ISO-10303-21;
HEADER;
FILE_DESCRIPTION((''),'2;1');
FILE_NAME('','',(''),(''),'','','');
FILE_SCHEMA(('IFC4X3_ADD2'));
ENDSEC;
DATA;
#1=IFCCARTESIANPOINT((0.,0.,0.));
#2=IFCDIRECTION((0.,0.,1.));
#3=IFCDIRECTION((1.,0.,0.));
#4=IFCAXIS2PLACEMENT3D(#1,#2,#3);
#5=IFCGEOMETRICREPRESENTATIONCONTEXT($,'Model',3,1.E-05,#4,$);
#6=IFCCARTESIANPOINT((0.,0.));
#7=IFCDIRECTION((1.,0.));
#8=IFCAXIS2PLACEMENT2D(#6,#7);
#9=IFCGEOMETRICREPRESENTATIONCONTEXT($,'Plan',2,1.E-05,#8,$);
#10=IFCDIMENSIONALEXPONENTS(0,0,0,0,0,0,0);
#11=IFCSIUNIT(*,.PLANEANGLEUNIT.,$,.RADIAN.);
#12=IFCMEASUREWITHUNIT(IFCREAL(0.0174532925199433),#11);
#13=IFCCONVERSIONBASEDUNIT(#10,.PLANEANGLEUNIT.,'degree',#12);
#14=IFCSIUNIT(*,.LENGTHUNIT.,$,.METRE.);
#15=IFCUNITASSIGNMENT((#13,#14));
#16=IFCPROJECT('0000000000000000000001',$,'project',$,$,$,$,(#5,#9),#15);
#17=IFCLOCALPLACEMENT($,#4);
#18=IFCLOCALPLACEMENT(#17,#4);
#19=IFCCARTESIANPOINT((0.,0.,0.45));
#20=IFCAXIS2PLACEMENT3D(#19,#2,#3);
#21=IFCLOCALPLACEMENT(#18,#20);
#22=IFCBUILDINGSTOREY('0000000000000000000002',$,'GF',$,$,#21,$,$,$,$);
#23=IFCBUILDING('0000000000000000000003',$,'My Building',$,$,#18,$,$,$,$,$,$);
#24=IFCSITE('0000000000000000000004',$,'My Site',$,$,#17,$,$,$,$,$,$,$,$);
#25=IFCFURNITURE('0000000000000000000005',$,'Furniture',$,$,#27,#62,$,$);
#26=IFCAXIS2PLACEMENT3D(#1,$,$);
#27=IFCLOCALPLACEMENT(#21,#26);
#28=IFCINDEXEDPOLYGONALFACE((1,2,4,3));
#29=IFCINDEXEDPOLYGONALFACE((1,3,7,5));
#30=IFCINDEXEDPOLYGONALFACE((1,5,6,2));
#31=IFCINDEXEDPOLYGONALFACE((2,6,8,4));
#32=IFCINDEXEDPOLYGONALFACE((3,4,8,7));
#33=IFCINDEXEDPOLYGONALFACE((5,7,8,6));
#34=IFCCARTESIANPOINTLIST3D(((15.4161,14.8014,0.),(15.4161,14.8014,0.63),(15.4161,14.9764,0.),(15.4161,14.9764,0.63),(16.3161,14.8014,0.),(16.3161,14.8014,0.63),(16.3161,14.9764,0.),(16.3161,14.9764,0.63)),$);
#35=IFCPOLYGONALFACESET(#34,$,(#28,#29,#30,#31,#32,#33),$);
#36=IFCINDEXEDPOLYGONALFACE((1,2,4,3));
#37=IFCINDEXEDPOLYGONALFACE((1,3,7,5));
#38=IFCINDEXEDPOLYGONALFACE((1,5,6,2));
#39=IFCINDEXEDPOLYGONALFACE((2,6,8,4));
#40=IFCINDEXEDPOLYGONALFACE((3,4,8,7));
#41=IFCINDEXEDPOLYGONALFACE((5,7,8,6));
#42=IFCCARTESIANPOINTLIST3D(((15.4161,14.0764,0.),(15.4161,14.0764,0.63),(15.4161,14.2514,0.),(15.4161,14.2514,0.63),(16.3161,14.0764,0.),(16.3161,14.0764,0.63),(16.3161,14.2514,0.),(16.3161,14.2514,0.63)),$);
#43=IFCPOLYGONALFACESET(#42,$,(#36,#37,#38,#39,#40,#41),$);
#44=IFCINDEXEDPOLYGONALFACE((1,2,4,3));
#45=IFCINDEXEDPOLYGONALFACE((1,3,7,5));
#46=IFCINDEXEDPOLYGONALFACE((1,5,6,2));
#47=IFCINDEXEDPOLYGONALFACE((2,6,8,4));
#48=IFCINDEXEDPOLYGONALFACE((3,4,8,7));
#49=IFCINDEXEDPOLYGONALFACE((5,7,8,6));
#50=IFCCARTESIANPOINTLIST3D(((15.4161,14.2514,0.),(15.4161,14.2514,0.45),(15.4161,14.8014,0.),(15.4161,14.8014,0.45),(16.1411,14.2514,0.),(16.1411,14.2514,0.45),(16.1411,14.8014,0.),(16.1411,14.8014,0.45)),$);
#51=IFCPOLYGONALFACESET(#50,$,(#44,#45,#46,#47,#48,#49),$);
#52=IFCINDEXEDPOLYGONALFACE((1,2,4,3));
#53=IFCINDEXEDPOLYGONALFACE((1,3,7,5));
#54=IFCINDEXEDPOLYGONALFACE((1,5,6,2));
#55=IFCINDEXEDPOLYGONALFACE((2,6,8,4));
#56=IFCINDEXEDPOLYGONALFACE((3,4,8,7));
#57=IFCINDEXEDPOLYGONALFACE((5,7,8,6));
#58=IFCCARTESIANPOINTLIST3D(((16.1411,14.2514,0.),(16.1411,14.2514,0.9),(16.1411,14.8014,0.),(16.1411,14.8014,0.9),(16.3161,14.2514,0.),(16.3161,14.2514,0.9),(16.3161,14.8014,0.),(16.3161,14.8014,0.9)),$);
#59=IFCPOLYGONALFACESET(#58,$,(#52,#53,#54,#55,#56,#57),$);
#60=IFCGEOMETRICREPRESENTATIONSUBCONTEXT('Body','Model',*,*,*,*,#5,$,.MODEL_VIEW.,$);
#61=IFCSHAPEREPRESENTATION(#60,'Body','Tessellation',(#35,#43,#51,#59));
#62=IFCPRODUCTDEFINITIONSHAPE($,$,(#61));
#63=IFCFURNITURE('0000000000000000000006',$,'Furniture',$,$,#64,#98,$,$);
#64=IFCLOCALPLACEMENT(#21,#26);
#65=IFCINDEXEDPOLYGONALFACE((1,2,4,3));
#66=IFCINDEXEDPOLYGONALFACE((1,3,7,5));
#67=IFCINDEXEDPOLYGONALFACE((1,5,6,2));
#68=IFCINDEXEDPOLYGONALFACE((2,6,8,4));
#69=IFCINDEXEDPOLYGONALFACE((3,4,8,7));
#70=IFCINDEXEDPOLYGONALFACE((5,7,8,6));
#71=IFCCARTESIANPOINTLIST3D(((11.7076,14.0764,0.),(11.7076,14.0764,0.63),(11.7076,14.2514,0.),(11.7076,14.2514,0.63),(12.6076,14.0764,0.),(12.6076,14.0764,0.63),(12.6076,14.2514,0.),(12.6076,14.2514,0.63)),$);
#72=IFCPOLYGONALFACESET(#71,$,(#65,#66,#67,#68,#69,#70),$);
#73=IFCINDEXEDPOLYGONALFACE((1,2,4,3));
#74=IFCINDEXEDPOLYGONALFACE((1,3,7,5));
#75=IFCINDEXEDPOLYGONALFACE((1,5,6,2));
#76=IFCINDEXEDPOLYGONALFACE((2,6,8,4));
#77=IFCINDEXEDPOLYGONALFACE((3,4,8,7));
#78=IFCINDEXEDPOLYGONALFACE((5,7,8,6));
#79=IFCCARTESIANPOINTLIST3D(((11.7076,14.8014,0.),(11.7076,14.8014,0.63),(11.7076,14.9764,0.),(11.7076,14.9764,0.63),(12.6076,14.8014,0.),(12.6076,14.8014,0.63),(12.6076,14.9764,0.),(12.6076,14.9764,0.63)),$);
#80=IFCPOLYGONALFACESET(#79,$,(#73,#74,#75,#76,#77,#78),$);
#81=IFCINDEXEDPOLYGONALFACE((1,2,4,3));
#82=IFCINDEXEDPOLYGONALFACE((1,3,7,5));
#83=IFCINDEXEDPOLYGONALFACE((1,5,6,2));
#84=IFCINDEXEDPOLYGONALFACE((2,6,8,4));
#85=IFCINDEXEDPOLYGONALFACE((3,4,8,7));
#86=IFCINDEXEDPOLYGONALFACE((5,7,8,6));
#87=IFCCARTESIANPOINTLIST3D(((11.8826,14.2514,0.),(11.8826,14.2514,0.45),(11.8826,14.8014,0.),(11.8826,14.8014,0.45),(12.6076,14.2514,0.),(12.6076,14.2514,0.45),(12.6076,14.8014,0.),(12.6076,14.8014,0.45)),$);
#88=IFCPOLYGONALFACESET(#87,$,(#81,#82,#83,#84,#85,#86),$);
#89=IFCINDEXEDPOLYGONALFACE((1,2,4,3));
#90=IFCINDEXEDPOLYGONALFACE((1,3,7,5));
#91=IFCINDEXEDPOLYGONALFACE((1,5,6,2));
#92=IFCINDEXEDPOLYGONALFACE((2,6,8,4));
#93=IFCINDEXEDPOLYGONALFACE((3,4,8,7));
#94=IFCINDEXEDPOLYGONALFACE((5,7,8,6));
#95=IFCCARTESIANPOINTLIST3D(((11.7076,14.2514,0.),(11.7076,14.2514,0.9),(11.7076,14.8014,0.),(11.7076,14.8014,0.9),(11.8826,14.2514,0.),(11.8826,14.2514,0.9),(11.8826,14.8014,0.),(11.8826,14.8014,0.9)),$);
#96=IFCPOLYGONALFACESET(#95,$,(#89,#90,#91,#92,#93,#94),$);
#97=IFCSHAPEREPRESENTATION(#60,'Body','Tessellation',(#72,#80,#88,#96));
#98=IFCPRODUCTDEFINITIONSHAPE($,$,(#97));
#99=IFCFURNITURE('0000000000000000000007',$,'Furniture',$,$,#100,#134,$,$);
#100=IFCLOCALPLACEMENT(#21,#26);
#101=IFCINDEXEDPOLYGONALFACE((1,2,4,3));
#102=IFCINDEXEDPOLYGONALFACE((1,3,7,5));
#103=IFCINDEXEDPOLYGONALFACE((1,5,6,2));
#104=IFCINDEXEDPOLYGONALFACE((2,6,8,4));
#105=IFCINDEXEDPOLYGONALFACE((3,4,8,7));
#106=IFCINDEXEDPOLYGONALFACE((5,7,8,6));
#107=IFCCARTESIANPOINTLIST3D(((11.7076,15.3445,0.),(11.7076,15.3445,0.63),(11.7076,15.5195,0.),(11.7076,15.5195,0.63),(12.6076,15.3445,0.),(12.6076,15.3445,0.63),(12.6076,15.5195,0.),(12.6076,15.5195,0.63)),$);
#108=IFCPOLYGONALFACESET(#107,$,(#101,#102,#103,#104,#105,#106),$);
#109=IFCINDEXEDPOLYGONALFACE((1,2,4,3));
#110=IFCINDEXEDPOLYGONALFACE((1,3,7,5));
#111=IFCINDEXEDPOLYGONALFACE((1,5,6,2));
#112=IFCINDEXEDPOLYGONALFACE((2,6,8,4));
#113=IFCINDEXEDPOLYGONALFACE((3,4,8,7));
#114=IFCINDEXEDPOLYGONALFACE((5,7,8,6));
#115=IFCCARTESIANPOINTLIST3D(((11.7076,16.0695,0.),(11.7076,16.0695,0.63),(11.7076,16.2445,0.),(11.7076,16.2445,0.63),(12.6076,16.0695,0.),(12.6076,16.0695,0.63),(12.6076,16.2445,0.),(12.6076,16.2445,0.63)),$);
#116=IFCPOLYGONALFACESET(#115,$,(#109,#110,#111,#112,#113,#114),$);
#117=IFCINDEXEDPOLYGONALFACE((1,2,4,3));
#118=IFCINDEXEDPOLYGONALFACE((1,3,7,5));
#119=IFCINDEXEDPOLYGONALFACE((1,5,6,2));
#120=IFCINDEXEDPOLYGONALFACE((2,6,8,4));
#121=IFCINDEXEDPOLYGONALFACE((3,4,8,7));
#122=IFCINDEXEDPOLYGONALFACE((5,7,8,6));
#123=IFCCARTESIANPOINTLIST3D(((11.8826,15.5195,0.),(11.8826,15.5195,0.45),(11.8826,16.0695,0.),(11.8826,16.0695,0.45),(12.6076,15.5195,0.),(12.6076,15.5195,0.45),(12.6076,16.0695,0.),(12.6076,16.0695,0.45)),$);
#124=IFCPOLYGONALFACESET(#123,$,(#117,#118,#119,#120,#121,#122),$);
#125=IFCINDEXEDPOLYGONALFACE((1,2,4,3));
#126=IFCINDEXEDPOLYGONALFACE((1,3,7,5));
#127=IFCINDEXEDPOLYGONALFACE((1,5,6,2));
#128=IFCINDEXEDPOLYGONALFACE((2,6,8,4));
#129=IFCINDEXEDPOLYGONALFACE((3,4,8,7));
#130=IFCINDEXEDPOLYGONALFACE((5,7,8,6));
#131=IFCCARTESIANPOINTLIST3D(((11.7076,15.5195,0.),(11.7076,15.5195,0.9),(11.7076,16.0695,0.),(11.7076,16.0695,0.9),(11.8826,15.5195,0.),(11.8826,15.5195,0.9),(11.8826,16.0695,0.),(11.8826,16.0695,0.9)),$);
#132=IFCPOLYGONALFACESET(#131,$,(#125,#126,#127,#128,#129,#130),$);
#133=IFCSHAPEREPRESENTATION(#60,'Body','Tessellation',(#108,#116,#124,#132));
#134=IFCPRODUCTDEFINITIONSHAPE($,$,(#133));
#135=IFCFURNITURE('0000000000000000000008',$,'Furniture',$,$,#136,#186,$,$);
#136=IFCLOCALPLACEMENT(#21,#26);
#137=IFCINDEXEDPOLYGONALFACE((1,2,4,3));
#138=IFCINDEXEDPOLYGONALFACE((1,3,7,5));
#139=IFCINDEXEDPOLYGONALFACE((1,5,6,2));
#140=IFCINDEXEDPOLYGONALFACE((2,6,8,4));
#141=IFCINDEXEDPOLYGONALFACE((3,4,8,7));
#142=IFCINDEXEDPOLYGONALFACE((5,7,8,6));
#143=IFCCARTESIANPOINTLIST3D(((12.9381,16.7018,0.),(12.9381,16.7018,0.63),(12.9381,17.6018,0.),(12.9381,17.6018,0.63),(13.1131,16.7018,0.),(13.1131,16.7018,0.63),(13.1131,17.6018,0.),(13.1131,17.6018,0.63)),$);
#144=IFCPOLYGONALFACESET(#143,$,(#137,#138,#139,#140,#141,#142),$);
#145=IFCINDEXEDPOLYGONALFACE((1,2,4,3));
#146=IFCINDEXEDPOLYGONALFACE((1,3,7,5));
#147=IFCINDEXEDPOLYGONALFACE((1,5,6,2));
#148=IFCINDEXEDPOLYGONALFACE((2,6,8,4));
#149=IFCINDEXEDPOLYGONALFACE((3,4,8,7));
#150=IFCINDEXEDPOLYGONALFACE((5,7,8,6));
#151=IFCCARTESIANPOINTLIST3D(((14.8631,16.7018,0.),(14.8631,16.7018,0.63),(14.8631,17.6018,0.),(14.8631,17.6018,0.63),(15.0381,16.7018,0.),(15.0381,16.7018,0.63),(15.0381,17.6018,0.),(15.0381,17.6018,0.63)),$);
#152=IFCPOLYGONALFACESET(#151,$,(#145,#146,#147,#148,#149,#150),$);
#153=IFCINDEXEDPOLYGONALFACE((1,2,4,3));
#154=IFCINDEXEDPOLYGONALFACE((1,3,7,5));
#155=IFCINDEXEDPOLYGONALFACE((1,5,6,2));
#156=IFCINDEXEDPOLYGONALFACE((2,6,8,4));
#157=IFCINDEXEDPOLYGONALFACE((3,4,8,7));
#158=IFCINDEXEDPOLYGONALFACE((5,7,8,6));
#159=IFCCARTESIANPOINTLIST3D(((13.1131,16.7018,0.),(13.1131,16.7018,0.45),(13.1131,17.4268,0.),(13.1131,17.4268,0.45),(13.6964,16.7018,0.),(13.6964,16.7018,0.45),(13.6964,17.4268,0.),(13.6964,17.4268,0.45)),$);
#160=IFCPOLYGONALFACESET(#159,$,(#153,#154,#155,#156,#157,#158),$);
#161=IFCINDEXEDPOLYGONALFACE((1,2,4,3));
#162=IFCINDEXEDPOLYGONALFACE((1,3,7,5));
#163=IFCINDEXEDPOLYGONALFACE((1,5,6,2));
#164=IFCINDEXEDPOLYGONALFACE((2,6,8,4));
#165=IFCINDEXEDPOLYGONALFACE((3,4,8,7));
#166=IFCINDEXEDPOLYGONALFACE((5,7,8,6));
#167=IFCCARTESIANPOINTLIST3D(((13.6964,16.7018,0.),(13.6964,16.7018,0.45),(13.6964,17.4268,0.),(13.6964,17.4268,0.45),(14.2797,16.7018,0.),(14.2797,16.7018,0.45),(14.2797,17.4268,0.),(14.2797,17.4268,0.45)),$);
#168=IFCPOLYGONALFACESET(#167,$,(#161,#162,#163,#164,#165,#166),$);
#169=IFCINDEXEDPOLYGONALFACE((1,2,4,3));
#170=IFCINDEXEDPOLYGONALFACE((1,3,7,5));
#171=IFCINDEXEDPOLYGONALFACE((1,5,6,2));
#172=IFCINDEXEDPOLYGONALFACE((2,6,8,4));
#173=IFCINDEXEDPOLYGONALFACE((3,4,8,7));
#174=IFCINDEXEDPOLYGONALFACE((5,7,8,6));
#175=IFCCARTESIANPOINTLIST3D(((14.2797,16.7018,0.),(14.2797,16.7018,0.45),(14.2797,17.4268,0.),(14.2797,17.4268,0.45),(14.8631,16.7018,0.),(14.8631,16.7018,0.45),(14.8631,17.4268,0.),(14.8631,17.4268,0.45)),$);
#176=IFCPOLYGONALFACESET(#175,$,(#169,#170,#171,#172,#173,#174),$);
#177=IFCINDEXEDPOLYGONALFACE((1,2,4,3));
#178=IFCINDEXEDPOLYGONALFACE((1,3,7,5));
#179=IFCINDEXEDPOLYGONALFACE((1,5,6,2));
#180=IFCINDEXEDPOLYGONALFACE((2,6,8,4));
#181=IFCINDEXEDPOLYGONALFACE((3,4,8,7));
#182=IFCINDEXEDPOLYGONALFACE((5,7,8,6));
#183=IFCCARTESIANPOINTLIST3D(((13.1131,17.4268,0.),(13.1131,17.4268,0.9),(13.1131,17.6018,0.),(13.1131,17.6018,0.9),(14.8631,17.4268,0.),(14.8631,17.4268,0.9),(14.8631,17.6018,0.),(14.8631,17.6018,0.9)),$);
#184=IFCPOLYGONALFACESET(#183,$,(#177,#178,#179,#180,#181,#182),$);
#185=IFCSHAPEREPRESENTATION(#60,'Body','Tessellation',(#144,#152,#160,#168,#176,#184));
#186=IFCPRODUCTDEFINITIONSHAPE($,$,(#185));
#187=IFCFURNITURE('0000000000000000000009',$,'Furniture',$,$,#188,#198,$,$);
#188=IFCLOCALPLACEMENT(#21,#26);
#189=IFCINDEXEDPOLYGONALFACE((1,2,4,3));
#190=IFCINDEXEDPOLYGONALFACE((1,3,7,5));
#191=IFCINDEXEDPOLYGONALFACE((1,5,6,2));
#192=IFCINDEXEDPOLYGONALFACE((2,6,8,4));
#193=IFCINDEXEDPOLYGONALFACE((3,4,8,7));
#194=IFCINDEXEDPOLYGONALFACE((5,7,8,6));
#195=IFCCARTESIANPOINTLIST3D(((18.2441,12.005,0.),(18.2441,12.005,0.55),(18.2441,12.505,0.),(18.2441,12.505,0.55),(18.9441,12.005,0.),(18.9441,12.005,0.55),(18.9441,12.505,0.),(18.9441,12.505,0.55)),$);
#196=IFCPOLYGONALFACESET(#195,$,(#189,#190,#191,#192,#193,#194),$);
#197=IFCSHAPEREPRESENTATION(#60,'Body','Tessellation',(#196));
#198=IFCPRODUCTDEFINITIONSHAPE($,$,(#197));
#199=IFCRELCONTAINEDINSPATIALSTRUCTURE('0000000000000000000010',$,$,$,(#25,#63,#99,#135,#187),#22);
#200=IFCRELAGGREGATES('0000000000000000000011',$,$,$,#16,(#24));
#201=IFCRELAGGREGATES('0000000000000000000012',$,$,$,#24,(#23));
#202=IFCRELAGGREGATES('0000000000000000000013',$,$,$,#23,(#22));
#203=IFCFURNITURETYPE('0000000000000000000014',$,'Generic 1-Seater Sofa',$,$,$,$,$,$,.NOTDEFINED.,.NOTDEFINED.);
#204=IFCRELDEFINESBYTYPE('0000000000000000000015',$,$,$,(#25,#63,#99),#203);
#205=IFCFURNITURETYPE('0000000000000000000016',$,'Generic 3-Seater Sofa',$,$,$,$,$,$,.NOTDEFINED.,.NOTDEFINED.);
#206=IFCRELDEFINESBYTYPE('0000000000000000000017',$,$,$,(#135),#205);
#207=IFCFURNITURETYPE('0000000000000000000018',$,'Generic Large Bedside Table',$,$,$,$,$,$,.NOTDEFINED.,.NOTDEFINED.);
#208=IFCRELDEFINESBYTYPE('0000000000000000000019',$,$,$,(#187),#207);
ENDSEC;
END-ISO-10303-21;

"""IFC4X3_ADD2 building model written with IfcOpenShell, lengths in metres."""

from ifc_helpers import new_model, entity, si_unit, converted_unit, frame, origin_with_axes, origin_2d_with_axis, place, context, subcontext, project, spatial, line, indexed_curve, outline, extrude, shape, source, transform, mapped, type_object, type_shapes, element, save


model = new_model("IFC4X3_ADD2")

# Units and contexts
model_context = context("Model", 3, precision=1e-05, world=origin_with_axes())
plan_context = context("Plan", 2, precision=1e-05, world=origin_2d_with_axis())
body_context_1 = subcontext(model_context, "Body", "Model", "MODEL_VIEW")
body_context_2 = subcontext(plan_context, "Body", "Plan", "PLAN_VIEW")
ifc_project = project(units=[converted_unit("PLANEANGLEUNIT", "degree", entity("IfcReal", 0.0174532925199433), si_unit("PLANEANGLEUNIT", "RADIAN"), dimensions=[0, 0, 0, 0, 0, 0, 0]), si_unit("LENGTHUNIT", "METRE")], contexts=[model_context, plan_context])

# Site, building, storey
site_placement = place(None, origin_with_axes())
site = spatial("IfcSite", under=ifc_project, at=site_placement, Name="My Site")
building_placement = place(site_placement, origin_with_axes())
building = spatial("IfcBuilding", under=site, at=building_placement, Name="My Building")
storey_placement = place(building_placement, frame((0.0, 0.0, 0.45), z_axis=(0.0, 0.0, 1.0), x_axis=(1.0, 0.0, 0.0)))
storey = spatial("IfcBuildingStorey", under=building, at=storey_placement, Name="GF")

# Furniture
furniture_type_1 = type_object("IfcFurnitureType", Name="Generic 1-Seater Sofa", AssemblyPlace="NOTDEFINED", PredefinedType="NOTDEFINED")
shared_shape_1 = source(origin_with_axes(), body_context_1, "Body", "SweptSolid", [
    extrude(outline(indexed_curve([(0.0, 0.0), (0.175, 0.0), (0.175, 0.9), (0.0, 0.9)], segments=[line(1, 2, 3, 4, 1)])), frame((-0.45, -0.9, 0.0), z_axis=(0.0, 0.0, 1.0), x_axis=(1.0, 0.0, 0.0)), (0.0, 0.0, 1.0), 0.63),
    extrude(outline(indexed_curve([(0.0, 0.0), (0.175, 0.0), (0.175, 0.9), (0.0, 0.9)], segments=[line(1, 2, 3, 4, 1)])), frame((0.275, -0.9, 0.0), z_axis=(0.0, 0.0, 1.0), x_axis=(1.0, 0.0, 0.0)), (0.0, 0.0, 1.0), 0.63),
    extrude(outline(indexed_curve([(0.175, 0.0), (0.725, 0.0), (0.725, 0.725), (0.175, 0.725)], segments=[line(1, 2, 3, 4, 1)])), frame((-0.45, -0.9, 0.0), z_axis=(0.0, 0.0, 1.0), x_axis=(1.0, 0.0, 0.0)), (0.0, 0.0, 1.0), 0.45),
    extrude(outline(indexed_curve([(0.175, 0.725), (0.725, 0.725), (0.725, 0.9), (0.175, 0.9)], segments=[line(1, 2, 3, 4, 1)])), frame((-0.45, -0.9, 0.0), z_axis=(0.0, 0.0, 1.0), x_axis=(1.0, 0.0, 0.0)), (0.0, 0.0, 1.0), 0.9),
])
shared_shape_2 = source(origin_with_axes(), body_context_2, "Body", "Annotation2D", [
    entity("IfcGeometricCurveSet", [entity("IfcIndexedPolyCurve", entity("IfcCartesianPointList2D", [[0.275, -0.175], [0.275, -0.9], [0.45, -0.9], [0.45, 0.0], [0.275, 0.0], [0.275, -0.9], [-0.275, -0.9], [-0.275, 0.0], [-0.275, -0.175], [0.275, -0.175], [0.275, 0.0], [-0.275, 0.0], [-0.45, 0.0], [-0.45, -0.9], [-0.275, -0.9], [-0.275, -0.175]]))]),
])
type_shapes(furniture_type_1, [shared_shape_1, shared_shape_2])
for number, where, z_axis, x_axis, name in (
    (1, (16.3161, 14.5264, 0.0), (0.0, 0.0, 1.0), (0.0, -1.0, 0.0), "Furniture"),
    (2, (11.7076, 14.5264, 0.0), (0.0, 0.0, 1.0), (0.000003, 1.0, 0.0), "Furniture"),
    (3, (11.7076, 15.7945, 0.0), (0.0, 0.0, 1.0), (0.000003, 1.0, 0.0), "Furniture"),
):
    element("IfcFurniture", number, at=place(storey_placement, frame(where, z_axis=z_axis, x_axis=x_axis)), inside=storey, type_object=furniture_type_1, Name=name, shapes=[
        shape(body_context_1, "Body", "MappedRepresentation", [mapped(shared_shape_1, transform((0.0, 0.0, 0.0), x_axis=(1.0, 0.0, 0.0), y_axis=(0.0, 1.0, 0.0), z_axis=(0.0, 0.0, 1.0), scale=1.0))]),
        shape(body_context_2, "Body", "MappedRepresentation", [mapped(shared_shape_2, transform((0.0, 0.0, 0.0), x_axis=(1.0, 0.0, 0.0), y_axis=(0.0, 1.0, 0.0), z_axis=(0.0, 0.0, 1.0), scale=1.0))]),
    ])
furniture_type_2 = type_object("IfcFurnitureType", Name="Generic 3-Seater Sofa", AssemblyPlace="NOTDEFINED", PredefinedType="NOTDEFINED")
shared_shape_3 = source(origin_with_axes(), body_context_1, "Body", "SweptSolid", [
    extrude(outline(indexed_curve([(0.0, 0.0), (0.175, 0.0), (0.175, 0.9), (0.0, 0.9)], segments=[line(1, 2, 3, 4, 1)])), frame((-1.05, -0.9, 0.0), z_axis=(0.0, 0.0, 1.0), x_axis=(1.0, 0.0, 0.0)), (0.0, 0.0, 1.0), 0.63),
    extrude(outline(indexed_curve([(0.0, 0.0), (0.175, 0.0), (0.175, 0.9), (0.0, 0.9)], segments=[line(1, 2, 3, 4, 1)])), frame((0.875, -0.9, 0.0), z_axis=(0.0, 0.0, 1.0), x_axis=(1.0, 0.0, 0.0)), (0.0, 0.0, 1.0), 0.63),
    extrude(outline(indexed_curve([(0.175, 0.0), (0.7583, 0.0), (0.7583, 0.725), (0.175, 0.725)], segments=[line(1, 2, 3, 4, 1)])), frame((-1.05, -0.9, 0.0), z_axis=(0.0, 0.0, 1.0), x_axis=(1.0, 0.0, 0.0)), (0.0, 0.0, 1.0), 0.45),
    extrude(outline(indexed_curve([(0.7583, 0.0), (1.3417, 0.0), (1.3417, 0.725), (0.7583, 0.725)], segments=[line(1, 2, 3, 4, 1)])), frame((-1.05, -0.9, 0.0), z_axis=(0.0, 0.0, 1.0), x_axis=(1.0, 0.0, 0.0)), (0.0, 0.0, 1.0), 0.45),
    extrude(outline(indexed_curve([(1.3417, 0.0), (1.925, 0.0), (1.925, 0.725), (1.3417, 0.725)], segments=[line(1, 2, 3, 4, 1)])), frame((-1.05, -0.9, 0.0), z_axis=(0.0, 0.0, 1.0), x_axis=(1.0, 0.0, 0.0)), (0.0, 0.0, 1.0), 0.45),
    extrude(outline(indexed_curve([(0.175, 0.725), (1.925, 0.725), (1.925, 0.9), (0.175, 0.9)], segments=[line(1, 2, 3, 4, 1)])), frame((-1.05, -0.9, 0.0), z_axis=(0.0, 0.0, 1.0), x_axis=(1.0, 0.0, 0.0)), (0.0, 0.0, 1.0), 0.9),
])
shared_shape_4 = source(origin_with_axes(), body_context_2, "Body", "Curve2D", [
    entity("IfcIndexedPolyCurve", entity("IfcCartesianPointList2D", [[-1.05, -0.9], [-0.875, -0.9], [-0.875, 0.0], [-1.05, 0.0]]), [entity("IfcLineIndex", [1, 2, 3, 4, 1])]),
    entity("IfcIndexedPolyCurve", entity("IfcCartesianPointList2D", [[0.875, -0.9], [1.05, -0.9], [1.05, 0.0], [0.875, 0.0]]), [entity("IfcLineIndex", [1, 2, 3, 4, 1])]),
    entity("IfcIndexedPolyCurve", entity("IfcCartesianPointList2D", [[-0.875, -0.9], [-0.2917, -0.9], [-0.2917, -0.175], [-0.875, -0.175]]), [entity("IfcLineIndex", [1, 2, 3, 4, 1])]),
    entity("IfcIndexedPolyCurve", entity("IfcCartesianPointList2D", [[-0.2917, -0.9], [0.2917, -0.9], [0.2917, -0.175], [-0.2917, -0.175]]), [entity("IfcLineIndex", [1, 2, 3, 4, 1])]),
    entity("IfcIndexedPolyCurve", entity("IfcCartesianPointList2D", [[0.2917, -0.9], [0.875, -0.9], [0.875, -0.175], [0.2917, -0.175]]), [entity("IfcLineIndex", [1, 2, 3, 4, 1])]),
    entity("IfcIndexedPolyCurve", entity("IfcCartesianPointList2D", [[-0.875, -0.175], [0.875, -0.175], [0.875, 0.0], [-0.875, 0.0]]), [entity("IfcLineIndex", [1, 2, 3, 4, 1])]),
])
type_shapes(furniture_type_2, [shared_shape_3, shared_shape_4])
furniture_1_placement = place(storey_placement, frame((13.9881, 17.6018, 0.0), z_axis=(0.0, 0.0, 1.0), x_axis=(1.0, 0.0, 0.0)))
element("IfcFurniture", 4, at=furniture_1_placement, inside=storey, type_object=furniture_type_2, Name="Furniture", shapes=[
    shape(body_context_1, "Body", "MappedRepresentation", [mapped(shared_shape_3, transform((0.0, 0.0, 0.0), x_axis=(1.0, 0.0, 0.0), y_axis=(0.0, 1.0, 0.0), z_axis=(0.0, 0.0, 1.0), scale=1.0))]),
    shape(body_context_2, "Body", "MappedRepresentation", [mapped(shared_shape_4, transform((0.0, 0.0, 0.0), x_axis=(1.0, 0.0, 0.0), y_axis=(0.0, 1.0, 0.0), z_axis=(0.0, 0.0, 1.0), scale=1.0))]),
])
furniture_type_3 = type_object("IfcFurnitureType", Name="Generic Large Bedside Table", AssemblyPlace="NOTDEFINED", PredefinedType="NOTDEFINED")
shared_shape_5 = source(origin_with_axes(), body_context_1, "Body", "SweptSolid", [
    extrude(outline(indexed_curve([(0.0, 0.0), (0.7, 0.0), (0.7, 0.5), (0.0, 0.5)], segments=[line(1, 2, 3, 4, 1)])), frame((-0.35, -0.25, 0.0), z_axis=(0.0, 0.0, 1.0), x_axis=(1.0, 0.0, 0.0)), (0.0, 0.0, 1.0), 0.55),
])
shared_shape_6 = source(origin_with_axes(), body_context_2, "Body", "Curve2D", [
    entity("IfcIndexedPolyCurve", entity("IfcCartesianPointList2D", [[-0.35, -0.25], [0.35, -0.25], [0.35, 0.25], [-0.35, 0.25]]), [entity("IfcLineIndex", [1, 2, 3, 4, 1])]),
])
type_shapes(furniture_type_3, [shared_shape_5, shared_shape_6])
for number, where, z_axis, x_axis, name in (
    (5, (18.5941, 12.255, 0.0), (0.0, 0.0, 1.0), (1.0, 0.0, 0.0), "Furniture"),
):
    element("IfcFurniture", number, at=place(storey_placement, frame(where, z_axis=z_axis, x_axis=x_axis)), inside=storey, type_object=furniture_type_3, Name=name, shapes=[
        shape(body_context_1, "Body", "MappedRepresentation", [mapped(shared_shape_5, transform((0.0, 0.0, 0.0), x_axis=(1.0, 0.0, 0.0), y_axis=(0.0, 1.0, 0.0), z_axis=(0.0, 0.0, 1.0), scale=1.0))]),
        shape(body_context_2, "Body", "MappedRepresentation", [mapped(shared_shape_6, transform((0.0, 0.0, 0.0), x_axis=(1.0, 0.0, 0.0), y_axis=(0.0, 1.0, 0.0), z_axis=(0.0, 0.0, 1.0), scale=1.0))]),
    ])

save(model, "model.ifc")
